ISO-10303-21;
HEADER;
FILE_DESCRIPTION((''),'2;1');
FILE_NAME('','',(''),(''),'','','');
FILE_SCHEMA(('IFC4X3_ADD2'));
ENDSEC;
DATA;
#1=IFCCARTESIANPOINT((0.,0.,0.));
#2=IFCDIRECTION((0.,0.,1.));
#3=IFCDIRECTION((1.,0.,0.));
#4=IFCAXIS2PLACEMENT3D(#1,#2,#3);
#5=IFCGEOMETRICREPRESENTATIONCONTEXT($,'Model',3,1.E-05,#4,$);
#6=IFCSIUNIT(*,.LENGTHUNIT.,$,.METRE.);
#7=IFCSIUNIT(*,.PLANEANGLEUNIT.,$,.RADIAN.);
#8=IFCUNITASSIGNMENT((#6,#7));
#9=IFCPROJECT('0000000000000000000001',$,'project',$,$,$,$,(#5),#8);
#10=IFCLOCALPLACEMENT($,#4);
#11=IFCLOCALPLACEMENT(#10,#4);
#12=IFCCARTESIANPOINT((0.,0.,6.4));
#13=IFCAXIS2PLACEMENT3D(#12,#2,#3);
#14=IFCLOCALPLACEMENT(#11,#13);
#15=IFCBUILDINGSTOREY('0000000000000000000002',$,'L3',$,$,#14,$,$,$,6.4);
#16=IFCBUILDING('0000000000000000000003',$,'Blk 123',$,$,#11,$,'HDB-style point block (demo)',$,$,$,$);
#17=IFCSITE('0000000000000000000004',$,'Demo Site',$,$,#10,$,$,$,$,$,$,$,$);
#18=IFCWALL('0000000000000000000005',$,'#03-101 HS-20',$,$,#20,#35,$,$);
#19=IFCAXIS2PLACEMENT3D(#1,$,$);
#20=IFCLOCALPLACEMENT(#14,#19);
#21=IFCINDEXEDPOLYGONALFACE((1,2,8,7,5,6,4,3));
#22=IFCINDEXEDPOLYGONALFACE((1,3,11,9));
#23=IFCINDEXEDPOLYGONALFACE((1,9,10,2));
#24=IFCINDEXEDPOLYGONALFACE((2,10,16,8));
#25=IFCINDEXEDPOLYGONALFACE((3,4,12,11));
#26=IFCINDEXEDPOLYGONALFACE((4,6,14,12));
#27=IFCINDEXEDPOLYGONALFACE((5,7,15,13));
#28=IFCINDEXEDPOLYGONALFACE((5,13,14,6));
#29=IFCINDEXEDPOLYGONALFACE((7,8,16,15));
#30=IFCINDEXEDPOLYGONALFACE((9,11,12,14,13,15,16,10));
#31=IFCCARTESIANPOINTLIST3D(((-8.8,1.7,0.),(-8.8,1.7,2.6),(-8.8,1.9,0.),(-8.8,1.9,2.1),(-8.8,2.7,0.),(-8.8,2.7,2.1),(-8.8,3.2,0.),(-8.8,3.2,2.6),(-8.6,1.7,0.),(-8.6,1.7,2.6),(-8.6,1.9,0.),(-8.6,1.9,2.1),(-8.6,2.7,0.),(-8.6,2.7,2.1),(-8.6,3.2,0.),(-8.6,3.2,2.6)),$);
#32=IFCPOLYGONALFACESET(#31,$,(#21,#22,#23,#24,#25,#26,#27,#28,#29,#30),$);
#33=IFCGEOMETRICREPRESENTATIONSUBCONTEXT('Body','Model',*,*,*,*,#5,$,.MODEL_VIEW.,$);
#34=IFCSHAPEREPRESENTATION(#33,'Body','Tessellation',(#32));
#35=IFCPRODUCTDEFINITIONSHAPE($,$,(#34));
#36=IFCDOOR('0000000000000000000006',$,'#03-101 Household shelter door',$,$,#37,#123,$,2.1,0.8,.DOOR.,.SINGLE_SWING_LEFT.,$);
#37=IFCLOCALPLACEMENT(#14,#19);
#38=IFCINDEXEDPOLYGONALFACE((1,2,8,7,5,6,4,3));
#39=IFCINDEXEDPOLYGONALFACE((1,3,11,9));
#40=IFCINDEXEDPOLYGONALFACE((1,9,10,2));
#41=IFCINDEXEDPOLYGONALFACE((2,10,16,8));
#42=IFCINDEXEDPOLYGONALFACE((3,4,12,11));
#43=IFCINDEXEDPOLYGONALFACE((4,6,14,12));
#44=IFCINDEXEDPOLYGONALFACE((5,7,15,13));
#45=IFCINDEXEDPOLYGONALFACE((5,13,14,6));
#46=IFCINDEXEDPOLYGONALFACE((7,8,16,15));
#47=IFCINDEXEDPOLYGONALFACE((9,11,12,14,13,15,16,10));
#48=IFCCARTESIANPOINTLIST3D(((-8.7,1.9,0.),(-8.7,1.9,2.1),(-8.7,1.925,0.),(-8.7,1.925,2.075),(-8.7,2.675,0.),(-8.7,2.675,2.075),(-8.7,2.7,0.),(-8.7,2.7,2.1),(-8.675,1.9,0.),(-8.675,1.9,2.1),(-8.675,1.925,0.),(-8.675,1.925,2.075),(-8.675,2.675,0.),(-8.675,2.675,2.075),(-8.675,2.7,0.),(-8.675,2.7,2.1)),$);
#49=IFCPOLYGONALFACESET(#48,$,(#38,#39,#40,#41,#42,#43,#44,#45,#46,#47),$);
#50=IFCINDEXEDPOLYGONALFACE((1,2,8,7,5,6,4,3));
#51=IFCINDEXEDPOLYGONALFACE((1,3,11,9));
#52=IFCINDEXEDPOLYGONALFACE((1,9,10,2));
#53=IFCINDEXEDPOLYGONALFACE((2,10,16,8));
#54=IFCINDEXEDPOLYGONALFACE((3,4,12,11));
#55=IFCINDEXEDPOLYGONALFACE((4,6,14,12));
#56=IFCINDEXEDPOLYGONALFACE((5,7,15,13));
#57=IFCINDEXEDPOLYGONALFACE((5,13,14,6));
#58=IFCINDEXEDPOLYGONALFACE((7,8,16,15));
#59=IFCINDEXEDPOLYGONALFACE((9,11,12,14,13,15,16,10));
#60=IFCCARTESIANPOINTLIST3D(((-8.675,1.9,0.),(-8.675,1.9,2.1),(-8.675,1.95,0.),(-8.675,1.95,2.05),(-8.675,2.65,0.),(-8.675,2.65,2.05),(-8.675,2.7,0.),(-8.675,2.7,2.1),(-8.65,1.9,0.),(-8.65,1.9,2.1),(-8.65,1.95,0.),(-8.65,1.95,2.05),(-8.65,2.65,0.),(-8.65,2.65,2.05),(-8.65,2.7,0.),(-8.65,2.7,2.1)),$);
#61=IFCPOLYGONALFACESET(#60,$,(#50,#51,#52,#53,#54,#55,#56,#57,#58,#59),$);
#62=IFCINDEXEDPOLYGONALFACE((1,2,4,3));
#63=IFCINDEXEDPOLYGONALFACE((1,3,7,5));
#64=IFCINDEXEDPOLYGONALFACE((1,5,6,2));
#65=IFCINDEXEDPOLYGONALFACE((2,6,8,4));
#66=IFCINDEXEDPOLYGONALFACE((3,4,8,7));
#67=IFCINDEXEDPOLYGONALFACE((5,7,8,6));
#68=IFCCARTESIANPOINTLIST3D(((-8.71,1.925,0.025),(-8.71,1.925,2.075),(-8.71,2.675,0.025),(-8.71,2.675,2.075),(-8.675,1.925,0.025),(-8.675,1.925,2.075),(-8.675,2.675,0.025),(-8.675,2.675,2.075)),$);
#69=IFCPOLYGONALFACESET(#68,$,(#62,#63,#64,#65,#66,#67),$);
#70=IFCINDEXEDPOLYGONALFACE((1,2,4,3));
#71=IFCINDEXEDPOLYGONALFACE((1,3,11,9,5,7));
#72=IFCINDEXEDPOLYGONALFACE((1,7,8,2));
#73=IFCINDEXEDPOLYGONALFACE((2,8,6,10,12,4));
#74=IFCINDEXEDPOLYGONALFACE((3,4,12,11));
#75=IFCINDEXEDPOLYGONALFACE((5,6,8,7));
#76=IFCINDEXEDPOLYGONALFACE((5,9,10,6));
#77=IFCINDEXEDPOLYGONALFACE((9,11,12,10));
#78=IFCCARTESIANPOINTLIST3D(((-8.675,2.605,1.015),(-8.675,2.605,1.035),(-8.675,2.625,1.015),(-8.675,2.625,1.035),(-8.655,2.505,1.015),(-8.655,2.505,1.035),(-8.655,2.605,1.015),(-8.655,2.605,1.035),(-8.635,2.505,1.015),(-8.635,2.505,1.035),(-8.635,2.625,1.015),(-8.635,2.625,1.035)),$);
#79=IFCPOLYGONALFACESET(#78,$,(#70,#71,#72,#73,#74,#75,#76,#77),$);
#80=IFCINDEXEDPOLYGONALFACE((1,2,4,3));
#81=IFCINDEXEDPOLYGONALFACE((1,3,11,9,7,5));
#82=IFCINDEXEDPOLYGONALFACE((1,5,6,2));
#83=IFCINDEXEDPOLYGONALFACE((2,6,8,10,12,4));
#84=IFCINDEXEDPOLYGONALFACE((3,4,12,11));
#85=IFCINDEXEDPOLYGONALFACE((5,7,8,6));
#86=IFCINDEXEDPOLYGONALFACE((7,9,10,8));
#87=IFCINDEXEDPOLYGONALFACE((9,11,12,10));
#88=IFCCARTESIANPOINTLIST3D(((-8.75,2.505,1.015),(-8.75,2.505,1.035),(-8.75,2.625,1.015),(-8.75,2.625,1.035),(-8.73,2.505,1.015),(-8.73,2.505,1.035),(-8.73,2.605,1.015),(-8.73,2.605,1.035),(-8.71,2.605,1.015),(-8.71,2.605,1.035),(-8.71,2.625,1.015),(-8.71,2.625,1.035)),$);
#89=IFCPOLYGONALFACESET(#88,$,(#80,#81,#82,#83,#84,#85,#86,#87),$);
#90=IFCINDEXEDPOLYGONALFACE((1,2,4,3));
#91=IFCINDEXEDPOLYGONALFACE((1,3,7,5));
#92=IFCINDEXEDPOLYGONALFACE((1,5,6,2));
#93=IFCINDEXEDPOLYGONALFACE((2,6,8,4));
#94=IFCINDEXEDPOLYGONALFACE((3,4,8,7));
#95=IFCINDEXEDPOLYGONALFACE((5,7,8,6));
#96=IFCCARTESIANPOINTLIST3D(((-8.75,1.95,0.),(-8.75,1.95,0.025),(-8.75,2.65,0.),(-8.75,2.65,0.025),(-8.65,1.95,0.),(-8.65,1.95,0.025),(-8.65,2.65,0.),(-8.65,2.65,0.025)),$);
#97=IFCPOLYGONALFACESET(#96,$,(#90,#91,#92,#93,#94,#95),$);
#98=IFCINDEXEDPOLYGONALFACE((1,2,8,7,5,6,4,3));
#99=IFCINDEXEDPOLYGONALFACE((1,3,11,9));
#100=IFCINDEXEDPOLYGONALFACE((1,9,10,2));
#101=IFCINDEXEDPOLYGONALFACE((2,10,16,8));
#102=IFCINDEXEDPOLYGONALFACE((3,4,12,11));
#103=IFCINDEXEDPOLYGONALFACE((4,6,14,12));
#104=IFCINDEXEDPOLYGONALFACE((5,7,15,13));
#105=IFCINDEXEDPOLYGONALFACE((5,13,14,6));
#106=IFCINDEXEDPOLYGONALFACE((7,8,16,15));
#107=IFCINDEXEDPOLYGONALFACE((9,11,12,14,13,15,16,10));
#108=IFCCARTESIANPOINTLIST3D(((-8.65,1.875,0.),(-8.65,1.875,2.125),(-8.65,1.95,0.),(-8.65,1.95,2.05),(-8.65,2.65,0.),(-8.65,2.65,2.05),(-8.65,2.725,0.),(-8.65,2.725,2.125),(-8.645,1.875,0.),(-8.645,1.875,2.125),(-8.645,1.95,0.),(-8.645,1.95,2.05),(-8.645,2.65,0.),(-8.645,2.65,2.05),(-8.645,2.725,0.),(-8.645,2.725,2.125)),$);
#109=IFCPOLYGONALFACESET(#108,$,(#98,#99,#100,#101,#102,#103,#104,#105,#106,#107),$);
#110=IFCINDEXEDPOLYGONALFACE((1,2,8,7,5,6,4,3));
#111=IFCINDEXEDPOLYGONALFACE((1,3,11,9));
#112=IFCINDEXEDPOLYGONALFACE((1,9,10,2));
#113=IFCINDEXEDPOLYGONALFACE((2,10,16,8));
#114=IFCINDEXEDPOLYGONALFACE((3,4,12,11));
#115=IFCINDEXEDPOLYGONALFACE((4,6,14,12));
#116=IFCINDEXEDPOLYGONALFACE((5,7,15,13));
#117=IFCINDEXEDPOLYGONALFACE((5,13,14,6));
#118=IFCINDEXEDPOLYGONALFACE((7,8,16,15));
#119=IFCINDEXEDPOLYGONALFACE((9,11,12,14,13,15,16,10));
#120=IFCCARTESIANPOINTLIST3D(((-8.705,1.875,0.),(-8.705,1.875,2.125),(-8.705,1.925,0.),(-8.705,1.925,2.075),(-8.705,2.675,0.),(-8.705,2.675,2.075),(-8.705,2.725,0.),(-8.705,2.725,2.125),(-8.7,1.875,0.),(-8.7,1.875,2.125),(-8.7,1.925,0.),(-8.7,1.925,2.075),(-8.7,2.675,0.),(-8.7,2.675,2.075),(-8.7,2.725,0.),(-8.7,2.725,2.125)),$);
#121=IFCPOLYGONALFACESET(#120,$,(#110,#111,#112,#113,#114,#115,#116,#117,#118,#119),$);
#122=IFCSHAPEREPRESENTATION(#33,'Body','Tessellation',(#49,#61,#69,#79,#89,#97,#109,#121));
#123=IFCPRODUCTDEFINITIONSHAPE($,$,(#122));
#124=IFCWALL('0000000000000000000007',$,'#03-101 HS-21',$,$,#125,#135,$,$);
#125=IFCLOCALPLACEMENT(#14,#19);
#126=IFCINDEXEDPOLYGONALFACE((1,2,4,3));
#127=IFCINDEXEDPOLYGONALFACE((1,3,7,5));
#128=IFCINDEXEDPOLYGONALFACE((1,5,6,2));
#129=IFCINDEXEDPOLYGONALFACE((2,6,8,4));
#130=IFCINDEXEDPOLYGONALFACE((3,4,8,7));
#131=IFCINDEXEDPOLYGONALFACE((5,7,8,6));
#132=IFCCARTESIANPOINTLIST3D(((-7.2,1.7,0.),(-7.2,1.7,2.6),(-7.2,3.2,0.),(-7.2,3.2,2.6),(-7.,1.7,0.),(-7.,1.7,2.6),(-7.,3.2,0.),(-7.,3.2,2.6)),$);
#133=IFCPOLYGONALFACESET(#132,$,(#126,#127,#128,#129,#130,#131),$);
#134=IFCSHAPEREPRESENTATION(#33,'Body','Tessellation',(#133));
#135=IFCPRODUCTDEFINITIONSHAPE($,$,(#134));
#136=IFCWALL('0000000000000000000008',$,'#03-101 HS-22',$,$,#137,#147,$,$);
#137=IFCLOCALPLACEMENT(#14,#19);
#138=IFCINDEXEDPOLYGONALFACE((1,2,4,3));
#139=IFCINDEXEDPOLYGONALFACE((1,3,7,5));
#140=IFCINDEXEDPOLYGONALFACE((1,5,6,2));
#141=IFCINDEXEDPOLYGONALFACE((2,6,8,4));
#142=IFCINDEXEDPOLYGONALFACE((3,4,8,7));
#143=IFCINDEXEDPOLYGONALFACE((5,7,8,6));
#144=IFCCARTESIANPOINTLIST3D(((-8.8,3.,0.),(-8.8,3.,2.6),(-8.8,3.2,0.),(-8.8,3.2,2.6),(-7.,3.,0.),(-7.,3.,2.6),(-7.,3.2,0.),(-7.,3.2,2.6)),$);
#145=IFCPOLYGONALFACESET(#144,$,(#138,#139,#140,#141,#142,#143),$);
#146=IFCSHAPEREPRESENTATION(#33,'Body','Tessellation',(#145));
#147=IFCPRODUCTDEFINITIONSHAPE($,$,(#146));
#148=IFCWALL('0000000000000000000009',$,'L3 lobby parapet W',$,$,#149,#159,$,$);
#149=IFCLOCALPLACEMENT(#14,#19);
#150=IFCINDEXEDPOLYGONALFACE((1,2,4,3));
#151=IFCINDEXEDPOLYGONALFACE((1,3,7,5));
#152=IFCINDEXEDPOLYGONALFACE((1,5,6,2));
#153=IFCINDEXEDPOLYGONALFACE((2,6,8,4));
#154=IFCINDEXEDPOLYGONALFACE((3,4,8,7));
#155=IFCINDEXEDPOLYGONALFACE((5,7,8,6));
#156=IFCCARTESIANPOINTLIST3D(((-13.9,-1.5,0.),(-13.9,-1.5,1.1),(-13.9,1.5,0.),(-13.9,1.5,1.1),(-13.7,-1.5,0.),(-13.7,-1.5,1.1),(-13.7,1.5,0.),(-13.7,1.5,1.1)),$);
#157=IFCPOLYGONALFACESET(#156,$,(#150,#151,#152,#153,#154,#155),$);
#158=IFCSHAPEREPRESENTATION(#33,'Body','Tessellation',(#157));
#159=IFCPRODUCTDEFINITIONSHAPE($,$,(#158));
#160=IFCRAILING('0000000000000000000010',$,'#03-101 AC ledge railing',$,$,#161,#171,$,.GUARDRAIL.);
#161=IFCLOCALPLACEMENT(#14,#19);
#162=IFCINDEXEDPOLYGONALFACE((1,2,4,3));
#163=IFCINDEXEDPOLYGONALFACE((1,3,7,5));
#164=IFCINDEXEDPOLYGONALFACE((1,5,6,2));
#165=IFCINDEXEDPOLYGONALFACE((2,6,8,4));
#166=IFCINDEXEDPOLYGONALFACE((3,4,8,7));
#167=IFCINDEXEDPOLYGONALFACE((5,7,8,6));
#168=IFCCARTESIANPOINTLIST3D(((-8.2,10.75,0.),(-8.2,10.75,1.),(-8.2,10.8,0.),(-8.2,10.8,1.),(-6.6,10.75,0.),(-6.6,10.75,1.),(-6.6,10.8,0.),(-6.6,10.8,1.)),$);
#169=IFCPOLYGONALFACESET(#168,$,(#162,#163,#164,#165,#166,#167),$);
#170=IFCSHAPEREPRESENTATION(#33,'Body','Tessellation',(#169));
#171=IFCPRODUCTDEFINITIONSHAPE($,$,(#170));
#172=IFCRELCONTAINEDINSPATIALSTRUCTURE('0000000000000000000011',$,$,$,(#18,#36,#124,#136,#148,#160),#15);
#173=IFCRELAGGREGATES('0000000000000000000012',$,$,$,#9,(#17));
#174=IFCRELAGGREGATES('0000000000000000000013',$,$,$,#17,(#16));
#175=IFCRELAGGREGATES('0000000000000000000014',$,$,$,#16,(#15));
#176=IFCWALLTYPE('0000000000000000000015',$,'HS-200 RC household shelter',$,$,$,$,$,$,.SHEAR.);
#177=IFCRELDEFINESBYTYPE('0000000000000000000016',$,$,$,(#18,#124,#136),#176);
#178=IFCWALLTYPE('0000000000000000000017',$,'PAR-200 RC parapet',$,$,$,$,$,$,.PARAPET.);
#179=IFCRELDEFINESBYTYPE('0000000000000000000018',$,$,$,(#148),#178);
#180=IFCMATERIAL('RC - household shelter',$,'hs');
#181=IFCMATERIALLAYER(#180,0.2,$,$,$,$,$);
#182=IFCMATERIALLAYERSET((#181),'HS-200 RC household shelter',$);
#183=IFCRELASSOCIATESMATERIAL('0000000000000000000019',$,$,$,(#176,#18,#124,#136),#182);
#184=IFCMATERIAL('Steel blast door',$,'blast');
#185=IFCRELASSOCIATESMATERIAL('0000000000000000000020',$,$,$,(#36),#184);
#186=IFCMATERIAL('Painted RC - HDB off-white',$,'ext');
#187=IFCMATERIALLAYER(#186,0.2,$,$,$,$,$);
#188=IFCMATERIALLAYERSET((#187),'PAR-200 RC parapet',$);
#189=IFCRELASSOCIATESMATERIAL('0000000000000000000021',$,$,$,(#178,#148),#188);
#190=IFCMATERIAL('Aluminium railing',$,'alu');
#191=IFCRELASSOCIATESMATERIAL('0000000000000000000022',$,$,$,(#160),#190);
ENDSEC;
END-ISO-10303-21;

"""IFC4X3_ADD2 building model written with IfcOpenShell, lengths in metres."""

from ifc_helpers import new_model, si_unit, frame, origin, origin_with_axes, place, context, subcontext, project, spatial, polyline, line, indexed_curve, outline, extrude, material, layer, layer_set, layer_usage, type_object, element, fill, save


model = new_model("IFC4X3_ADD2")

# Units and contexts
model_context = context("Model", 3, precision=1e-05, world=origin_with_axes())
body_context = subcontext(model_context, "Body", "Model", "MODEL_VIEW")
ifc_project = project(units=[si_unit("LENGTHUNIT", "METRE"), si_unit("PLANEANGLEUNIT", "RADIAN")], contexts=[model_context])

# Site, building, storey
site_placement = place(None, origin_with_axes())
site = spatial("IfcSite", under=ifc_project, at=site_placement, Name="Demo Site")
building_placement = place(site_placement, origin_with_axes())
building = spatial("IfcBuilding", under=site, at=building_placement, Name="Blk 123", LongName="HDB-style point block (demo)")
storey_placement = place(building_placement, frame((0.0, 0.0, 6.4), z_axis=(0.0, 0.0, 1.0), x_axis=(1.0, 0.0, 0.0)))
storey = spatial("IfcBuildingStorey", under=building, at=storey_placement, Name="L3", Elevation=6.4)

# Shared definitions
ifc_material_1 = material(Name="Painted RC - HDB off-white", Category="ext")

# Wall, opening, door
ifc_material_2 = material(Name="RC - household shelter", Category="hs")
ifc_layer_1 = layer(ifc_material_2, 0.2)
ifc_layer_set_1 = layer_set([ifc_layer_1], Name="HS-200 RC household shelter")
ifc_layer_usage_1 = layer_usage(ifc_layer_set_1, "AXIS2", "POSITIVE", -0.1)
wall_type_1 = type_object("IfcWallType", Name="HS-200 RC household shelter", PredefinedType="SHEAR", material=ifc_layer_set_1)
wall_1_placement = place(storey_placement, frame((-8.7, 1.7, 0.0), z_axis=(0.0, 0.0, 1.0), x_axis=(0.0, 1.0, 0.0)))
wall_1 = element("IfcWall", 1, at=wall_1_placement, inside=storey, type_object=wall_type_1, material=ifc_layer_usage_1, Name="#03-101 HS-20", context=body_context, shape_type="SweptSolid", body=[
    extrude(outline(indexed_curve([(0.0, 0.0), (0.0, 0.2), (1.5, 0.2), (1.5, 0.0), (0.0, 0.0)], self_intersect=False)), frame((0.0, -0.1, 0.0), z_axis=(0.0, 0.0, 1.0), x_axis=(1.0, 0.0, 0.0)), (0.0, 0.0, 1.0), 2.6),
])
opening_1_placement = place(wall_1_placement, frame((0.2, -0.2, 0.0), z_axis=(0.0, 0.0, 1.0), x_axis=(1.0, 0.0, 0.0)))
opening_1 = element("IfcOpeningElement", 2, at=opening_1_placement, cuts=wall_1, context=body_context, shape_type="SweptSolid", body=[
    extrude(outline(indexed_curve([(0.0, 0.0), (0.0, 0.4), (0.8, 0.4), (0.8, 0.0), (0.0, 0.0)], self_intersect=False)), origin_with_axes(), (0.0, 0.0, 1.0), 2.1),
])
ifc_material_3 = material(Name="Steel blast door", Category="blast")
door_1_placement = place(opening_1_placement, frame((0.0, 0.15, 0.0), z_axis=(0.0, 0.0, 1.0), x_axis=(1.0, 0.0, 0.0)))
door_1 = element("IfcDoor", 3, at=door_1_placement, inside=storey, material=ifc_material_3, Name="#03-101 Household shelter door", OperationType="SINGLE_SWING_LEFT", OverallHeight=2.1, OverallWidth=0.8, PredefinedType="DOOR", context=body_context, shape_type="SweptSolid", body=[
    extrude(outline(indexed_curve([(0.0, 0.0), (0.0, 2.1), (0.8, 2.1), (0.8, 0.0), (0.775, 0.0), (0.775, 2.075), (0.025, 2.075), (0.025, 0.0)], segments=[line(1, 2, 3, 4, 5, 6, 7, 8, 1)])), frame((0.0, 0.025, 0.0), z_axis=(0.0, -1.0, 0.0), x_axis=(1.0, 0.0, 0.0)), (0.0, 0.0, -1.0), 0.025),
    extrude(outline(indexed_curve([(0.0, 0.0), (0.0, 2.1), (0.8, 2.1), (0.8, 0.0), (0.75, 0.0), (0.75, 2.05), (0.05, 2.05), (0.05, 0.0)], segments=[line(1, 2, 3, 4, 5, 6, 7, 8, 1)])), frame((0.0, 0.0, 0.0), z_axis=(0.0, -1.0, 0.0), x_axis=(1.0, 0.0, 0.0)), (0.0, 0.0, -1.0), 0.025),
    extrude(outline(indexed_curve([(0.0, 0.0), (0.75, 0.0), (0.75, 0.035), (0.0, 0.035)], segments=[line(1, 2, 3, 4, 1)])), frame((0.025, 0.025, 0.025), z_axis=(0.0, 0.0, 1.0), x_axis=(1.0, 0.0, 0.0)), (0.0, 0.0, 1.0), 2.05),
    extrude(outline(indexed_curve([(0.0, 0.0), (0.0, -0.04), (-0.12, -0.04), (-0.12, -0.02), (-0.02, -0.02), (-0.02, 0.0)], segments=[line(1, 2, 3, 4, 5, 6, 1)])), frame((0.725, 0.025, 1.015), z_axis=(0.0, 0.0, 1.0), x_axis=(1.0, 0.0, 0.0)), (0.0, 0.0, 1.0), 0.02),
    extrude(outline(indexed_curve([(0.0, 0.0), (0.0, 0.04), (-0.12, 0.04), (-0.12, 0.02), (-0.02, 0.02), (-0.02, 0.0)], segments=[line(1, 2, 3, 4, 5, 6, 1)])), frame((0.725, 0.06, 1.015), z_axis=(0.0, 0.0, 1.0), x_axis=(1.0, 0.0, 0.0)), (0.0, 0.0, 1.0), 0.02),
    extrude(outline(indexed_curve([(0.0, 0.0), (0.7, 0.0), (0.7, 0.1), (0.0, 0.1)], segments=[line(1, 2, 3, 4, 1)])), frame((0.05, 0.0, 0.0), z_axis=(0.0, 0.0, 1.0), x_axis=(1.0, 0.0, 0.0)), (0.0, 0.0, 1.0), 0.025),
    extrude(outline(indexed_curve([(0.0, 0.0), (0.0, 2.125), (0.85, 2.125), (0.85, 0.0), (0.775, 0.0), (0.775, 2.05), (0.075, 2.05), (0.075, 0.0)], segments=[line(1, 2, 3, 4, 5, 6, 7, 8, 1)])), frame((-0.025, -0.005, 0.0), z_axis=(0.0, -1.0, 0.0), x_axis=(1.0, 0.0, 0.0)), (0.0, 0.0, -1.0), 0.005),
    extrude(outline(indexed_curve([(0.0, 0.0), (0.0, 2.125), (0.85, 2.125), (0.85, 0.0), (0.8, 0.0), (0.8, 2.075), (0.05, 2.075), (0.05, 0.0)], segments=[line(1, 2, 3, 4, 5, 6, 7, 8, 1)])), frame((-0.025, 0.05, 0.0), z_axis=(0.0, -1.0, 0.0), x_axis=(1.0, 0.0, 0.0)), (0.0, 0.0, -1.0), 0.005),
])
fill(opening_1, door_1)

# Walls
wall_2_placement = place(storey_placement, frame((-7.1, 1.7, 0.0), z_axis=(0.0, 0.0, 1.0), x_axis=(0.0, 1.0, 0.0)))
element("IfcWall", 4, at=wall_2_placement, inside=storey, type_object=wall_type_1, material=ifc_layer_usage_1, Name="#03-101 HS-21", context=body_context, shape_type="SweptSolid", body=[
    extrude(outline(indexed_curve([(0.0, 0.0), (0.0, 0.2), (1.5, 0.2), (1.5, 0.0), (0.0, 0.0)], self_intersect=False)), frame((0.0, -0.1, 0.0), z_axis=(0.0, 0.0, 1.0), x_axis=(1.0, 0.0, 0.0)), (0.0, 0.0, 1.0), 2.6),
])
wall_3_placement = place(storey_placement, frame((-7.0, 3.1, 0.0), z_axis=(0.0, 0.0, 1.0), x_axis=(-1.0, 0.0, 0.0)))
element("IfcWall", 5, at=wall_3_placement, inside=storey, type_object=wall_type_1, material=ifc_layer_usage_1, Name="#03-101 HS-22", context=body_context, shape_type="SweptSolid", body=[
    extrude(outline(indexed_curve([(0.0, 0.0), (0.0, 0.2), (1.8, 0.2), (1.8, 0.0), (0.0, 0.0)], self_intersect=False)), frame((0.0, -0.1, 0.0), z_axis=(0.0, 0.0, 1.0), x_axis=(1.0, 0.0, 0.0)), (0.0, 0.0, 1.0), 2.6),
])
ifc_layer_2 = layer(ifc_material_1, 0.2)
ifc_layer_set_2 = layer_set([ifc_layer_2], Name="PAR-200 RC parapet")
ifc_layer_usage_2 = layer_usage(ifc_layer_set_2, "AXIS2", "POSITIVE", 0.0)
wall_type_2 = type_object("IfcWallType", Name="PAR-200 RC parapet", PredefinedType="PARAPET", material=ifc_layer_set_2)
wall_4_placement = place(storey_placement, frame((-13.9, 1.5, 0.0), z_axis=(0.0, 0.0, 1.0), x_axis=(0.0, -1.0, 0.0)))
element("IfcWall", 6, at=wall_4_placement, inside=storey, type_object=wall_type_2, material=ifc_layer_usage_2, Name="L3 lobby parapet W", context=body_context, shape_type="SweptSolid", body=[
    extrude(outline(indexed_curve([(0.0, 0.0), (0.0, 0.2), (3.0, 0.2), (3.0, 0.0), (0.0, 0.0)], self_intersect=False)), origin_with_axes(), (0.0, 0.0, 1.0), 1.1),
])

# Railing
ifc_material_4 = material(Name="Aluminium railing", Category="alu")
railing_placement = place(storey_placement, frame((-7.4, 10.775, 0.0), z_axis=(0.0, 0.0, 1.0), x_axis=(1.0, 0.0, 0.0)))
element("IfcRailing", 7, at=railing_placement, inside=storey, material=ifc_material_4, Name="#03-101 AC ledge railing", PredefinedType="GUARDRAIL", context=body_context, shape_type="SweptSolid", body=[
    extrude(outline(polyline([(-0.8, -0.025), (0.8, -0.025), (0.8, 0.025), (-0.8, 0.025), (-0.8, -0.025)])), origin(), (0.0, 0.0, 1.0), 1.0),
])

save(model, "model.ifc")
